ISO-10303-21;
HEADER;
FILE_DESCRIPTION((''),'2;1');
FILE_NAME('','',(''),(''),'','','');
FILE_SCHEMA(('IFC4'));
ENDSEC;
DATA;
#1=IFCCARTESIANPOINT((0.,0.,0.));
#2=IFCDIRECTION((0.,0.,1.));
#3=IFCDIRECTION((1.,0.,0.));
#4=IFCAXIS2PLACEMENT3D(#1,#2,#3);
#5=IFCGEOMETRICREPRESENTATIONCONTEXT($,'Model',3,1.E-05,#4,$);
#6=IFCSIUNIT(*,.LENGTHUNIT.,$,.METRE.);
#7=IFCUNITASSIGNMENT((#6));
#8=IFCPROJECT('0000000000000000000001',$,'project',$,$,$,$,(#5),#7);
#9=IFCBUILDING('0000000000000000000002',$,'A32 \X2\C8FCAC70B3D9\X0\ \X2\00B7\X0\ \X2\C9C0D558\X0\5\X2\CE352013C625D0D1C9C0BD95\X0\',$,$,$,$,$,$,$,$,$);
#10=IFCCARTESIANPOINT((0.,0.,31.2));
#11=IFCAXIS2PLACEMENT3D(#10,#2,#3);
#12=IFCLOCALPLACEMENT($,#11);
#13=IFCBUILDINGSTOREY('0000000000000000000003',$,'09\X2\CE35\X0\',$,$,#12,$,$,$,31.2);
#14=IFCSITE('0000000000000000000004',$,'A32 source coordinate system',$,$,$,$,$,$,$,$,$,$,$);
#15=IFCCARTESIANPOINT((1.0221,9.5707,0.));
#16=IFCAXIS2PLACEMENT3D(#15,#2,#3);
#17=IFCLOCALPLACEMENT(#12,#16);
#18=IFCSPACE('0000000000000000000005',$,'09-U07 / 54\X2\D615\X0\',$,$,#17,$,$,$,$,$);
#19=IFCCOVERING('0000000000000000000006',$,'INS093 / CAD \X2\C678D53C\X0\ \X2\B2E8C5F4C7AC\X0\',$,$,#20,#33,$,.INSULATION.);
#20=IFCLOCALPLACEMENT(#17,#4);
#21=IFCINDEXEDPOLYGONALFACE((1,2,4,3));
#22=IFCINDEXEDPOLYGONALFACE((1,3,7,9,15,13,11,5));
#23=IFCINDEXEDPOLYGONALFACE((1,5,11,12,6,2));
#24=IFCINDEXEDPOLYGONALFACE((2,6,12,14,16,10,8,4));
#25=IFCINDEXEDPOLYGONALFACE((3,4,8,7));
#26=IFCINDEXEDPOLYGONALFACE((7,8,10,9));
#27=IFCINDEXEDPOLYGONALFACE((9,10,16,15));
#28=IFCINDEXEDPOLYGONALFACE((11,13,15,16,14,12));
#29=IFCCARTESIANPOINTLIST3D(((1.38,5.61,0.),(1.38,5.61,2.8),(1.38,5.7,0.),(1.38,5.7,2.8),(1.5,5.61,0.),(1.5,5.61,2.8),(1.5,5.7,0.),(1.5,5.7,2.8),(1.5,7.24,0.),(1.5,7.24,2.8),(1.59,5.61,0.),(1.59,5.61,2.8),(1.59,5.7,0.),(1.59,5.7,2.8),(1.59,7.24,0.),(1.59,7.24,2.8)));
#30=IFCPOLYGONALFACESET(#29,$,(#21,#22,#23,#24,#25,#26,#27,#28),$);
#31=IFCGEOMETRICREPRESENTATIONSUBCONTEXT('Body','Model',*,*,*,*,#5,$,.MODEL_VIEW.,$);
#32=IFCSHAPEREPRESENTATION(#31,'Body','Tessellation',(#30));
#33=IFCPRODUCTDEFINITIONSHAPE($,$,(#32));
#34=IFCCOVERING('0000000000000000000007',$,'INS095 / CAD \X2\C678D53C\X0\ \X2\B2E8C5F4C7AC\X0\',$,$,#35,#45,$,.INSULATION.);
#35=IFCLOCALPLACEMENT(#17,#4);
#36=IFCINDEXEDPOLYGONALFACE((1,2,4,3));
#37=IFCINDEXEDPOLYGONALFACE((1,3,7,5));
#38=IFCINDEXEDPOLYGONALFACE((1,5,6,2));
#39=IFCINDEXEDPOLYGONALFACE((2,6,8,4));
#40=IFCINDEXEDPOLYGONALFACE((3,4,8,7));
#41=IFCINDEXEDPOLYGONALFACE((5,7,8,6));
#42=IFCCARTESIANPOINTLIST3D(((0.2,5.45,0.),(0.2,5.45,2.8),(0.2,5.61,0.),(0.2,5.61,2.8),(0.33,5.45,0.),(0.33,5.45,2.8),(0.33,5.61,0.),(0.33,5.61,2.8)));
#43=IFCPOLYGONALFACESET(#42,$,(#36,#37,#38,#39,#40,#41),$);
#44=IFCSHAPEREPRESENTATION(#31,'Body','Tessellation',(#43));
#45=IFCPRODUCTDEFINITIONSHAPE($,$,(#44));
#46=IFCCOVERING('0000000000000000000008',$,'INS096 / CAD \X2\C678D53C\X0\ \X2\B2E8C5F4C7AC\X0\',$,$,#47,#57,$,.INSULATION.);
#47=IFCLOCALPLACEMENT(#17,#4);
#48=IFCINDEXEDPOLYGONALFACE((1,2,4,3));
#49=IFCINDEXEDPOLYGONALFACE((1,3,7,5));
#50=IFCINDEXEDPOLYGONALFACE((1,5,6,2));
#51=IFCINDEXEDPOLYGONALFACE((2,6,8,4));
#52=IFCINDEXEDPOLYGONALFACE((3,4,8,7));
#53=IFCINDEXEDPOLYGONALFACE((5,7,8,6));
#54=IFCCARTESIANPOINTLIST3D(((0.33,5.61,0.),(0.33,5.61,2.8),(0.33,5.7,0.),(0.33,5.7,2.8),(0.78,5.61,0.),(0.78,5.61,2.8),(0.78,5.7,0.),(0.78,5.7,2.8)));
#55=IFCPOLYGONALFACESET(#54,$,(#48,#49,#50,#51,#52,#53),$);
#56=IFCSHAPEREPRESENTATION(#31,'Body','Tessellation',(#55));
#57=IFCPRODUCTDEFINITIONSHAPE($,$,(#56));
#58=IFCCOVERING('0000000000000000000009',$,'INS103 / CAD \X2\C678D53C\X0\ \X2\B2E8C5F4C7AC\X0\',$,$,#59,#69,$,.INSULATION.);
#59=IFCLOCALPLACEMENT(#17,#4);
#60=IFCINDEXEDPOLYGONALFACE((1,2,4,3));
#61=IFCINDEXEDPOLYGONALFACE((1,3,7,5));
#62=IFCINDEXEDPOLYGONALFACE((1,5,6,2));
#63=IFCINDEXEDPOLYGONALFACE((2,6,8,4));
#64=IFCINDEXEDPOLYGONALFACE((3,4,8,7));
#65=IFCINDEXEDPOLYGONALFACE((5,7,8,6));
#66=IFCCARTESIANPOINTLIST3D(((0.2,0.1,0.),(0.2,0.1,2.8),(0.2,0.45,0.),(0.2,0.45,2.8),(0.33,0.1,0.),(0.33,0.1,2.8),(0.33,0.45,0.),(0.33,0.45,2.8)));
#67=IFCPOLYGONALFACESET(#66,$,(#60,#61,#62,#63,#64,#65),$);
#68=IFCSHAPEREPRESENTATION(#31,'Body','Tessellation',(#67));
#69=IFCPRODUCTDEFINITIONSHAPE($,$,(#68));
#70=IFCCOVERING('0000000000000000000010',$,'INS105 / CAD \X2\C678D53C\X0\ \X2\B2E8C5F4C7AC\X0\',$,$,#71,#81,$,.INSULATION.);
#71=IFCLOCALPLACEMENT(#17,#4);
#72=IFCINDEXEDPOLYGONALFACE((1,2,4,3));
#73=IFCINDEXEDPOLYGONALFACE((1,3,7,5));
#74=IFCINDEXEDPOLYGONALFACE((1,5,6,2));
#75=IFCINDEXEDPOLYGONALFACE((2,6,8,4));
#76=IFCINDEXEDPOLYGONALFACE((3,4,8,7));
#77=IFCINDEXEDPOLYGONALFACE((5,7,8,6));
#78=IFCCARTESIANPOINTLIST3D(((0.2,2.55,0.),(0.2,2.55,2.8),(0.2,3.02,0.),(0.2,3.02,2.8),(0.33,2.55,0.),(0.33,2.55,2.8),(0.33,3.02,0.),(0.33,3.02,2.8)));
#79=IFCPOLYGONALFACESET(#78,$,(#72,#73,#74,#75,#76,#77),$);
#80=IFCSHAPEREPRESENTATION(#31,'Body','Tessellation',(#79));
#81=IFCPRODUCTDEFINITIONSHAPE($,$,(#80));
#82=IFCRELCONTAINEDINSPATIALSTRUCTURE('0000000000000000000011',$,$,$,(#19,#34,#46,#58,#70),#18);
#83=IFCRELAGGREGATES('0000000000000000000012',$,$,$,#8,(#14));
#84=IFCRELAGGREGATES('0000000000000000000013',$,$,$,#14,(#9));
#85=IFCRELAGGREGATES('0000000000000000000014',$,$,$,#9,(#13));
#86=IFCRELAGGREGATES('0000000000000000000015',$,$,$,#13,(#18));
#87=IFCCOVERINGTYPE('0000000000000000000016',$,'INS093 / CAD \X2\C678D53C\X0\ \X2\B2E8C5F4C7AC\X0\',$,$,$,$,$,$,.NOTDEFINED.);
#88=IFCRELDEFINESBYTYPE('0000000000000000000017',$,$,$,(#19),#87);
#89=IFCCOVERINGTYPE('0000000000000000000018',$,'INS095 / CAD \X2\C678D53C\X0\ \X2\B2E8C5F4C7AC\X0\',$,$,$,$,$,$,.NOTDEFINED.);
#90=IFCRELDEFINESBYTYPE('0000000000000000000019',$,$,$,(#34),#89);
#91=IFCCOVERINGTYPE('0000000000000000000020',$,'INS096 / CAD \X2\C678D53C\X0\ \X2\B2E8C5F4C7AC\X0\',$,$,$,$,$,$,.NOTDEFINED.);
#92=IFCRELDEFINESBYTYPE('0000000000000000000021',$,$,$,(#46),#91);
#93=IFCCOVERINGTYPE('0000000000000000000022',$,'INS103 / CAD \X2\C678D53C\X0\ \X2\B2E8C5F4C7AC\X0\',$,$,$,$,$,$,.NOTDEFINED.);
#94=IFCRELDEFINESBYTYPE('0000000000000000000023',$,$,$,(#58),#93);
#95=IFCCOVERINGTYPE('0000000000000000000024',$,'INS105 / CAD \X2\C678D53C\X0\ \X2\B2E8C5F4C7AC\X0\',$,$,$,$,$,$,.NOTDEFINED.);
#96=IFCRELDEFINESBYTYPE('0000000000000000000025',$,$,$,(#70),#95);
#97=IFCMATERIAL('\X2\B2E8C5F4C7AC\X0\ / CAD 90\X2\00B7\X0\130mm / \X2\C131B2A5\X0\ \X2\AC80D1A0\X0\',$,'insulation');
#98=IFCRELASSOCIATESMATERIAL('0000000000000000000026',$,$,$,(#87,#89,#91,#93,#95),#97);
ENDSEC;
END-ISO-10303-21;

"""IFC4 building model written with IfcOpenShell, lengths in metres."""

from ifc_helpers import new_model, si_unit, frame, origin, origin_with_axes, place, context, subcontext, project, spatial, polyline, outline, extrude, source, transform, mapped, material, type_object, type_shapes, element, save


model = new_model("IFC4")

# Units and contexts
model_context = context("Model", 3, precision=1e-05, world=origin_with_axes())
body_context = subcontext(model_context, "Body", "Model", "MODEL_VIEW")
ifc_project = project(units=[si_unit("LENGTHUNIT", "METRE")], contexts=[model_context])

# Site, building, storey, space
storey_placement = place(None, frame((0.0, 0.0, 31.2), z_axis=(0.0, 0.0, 1.0), x_axis=(1.0, 0.0, 0.0)))
space_placement = place(storey_placement, frame((1.0221, 9.5707, 0.0), z_axis=(0.0, 0.0, 1.0), x_axis=(1.0, 0.0, 0.0)))
site = spatial("IfcSite", under=ifc_project, Name="A32 source coordinate system")
building = spatial("IfcBuilding", under=site, Name="A32 주거동 · 지하5층–옥탑지붕")
storey = spatial("IfcBuildingStorey", under=building, at=storey_placement, Name="09층", Elevation=31.2)
space = spatial("IfcSpace", under=storey, at=space_placement, Name="09-U07 / 54형")

# Coverings
ifc_material = material(Name="단열재 / CAD 90·130mm / 성능 검토", Category="insulation")
covering_type_1 = type_object("IfcCoveringType", Name="INS093 / CAD 외피 단열재", PredefinedType="NOTDEFINED", material=ifc_material)
shared_shape_1 = source(origin(), body_context, "Body", "SweptSolid", [
    extrude(outline(polyline([(1.5, 5.7), (1.5, 7.24), (1.59, 7.24), (1.59, 5.7), (1.59, 5.61), (1.5, 5.61), (1.38, 5.61), (1.38, 5.7), (1.5, 5.7)])), origin(), (0.0, 0.0, 1.0), 2.8),
])
type_shapes(covering_type_1, [shared_shape_1])
covering_1_placement = place(space_placement, origin_with_axes())
element("IfcCovering", 1, at=covering_1_placement, inside=space, type_object=covering_type_1, Name="INS093 / CAD 외피 단열재", PredefinedType="INSULATION", context=body_context, shape_type="MappedRepresentation", body=[
    mapped(shared_shape_1, transform((0.0, 0.0, 0.0), scale=1.0)),
])
covering_type_2 = type_object("IfcCoveringType", Name="INS095 / CAD 외피 단열재", PredefinedType="NOTDEFINED", material=ifc_material)
shared_shape_2 = source(origin(), body_context, "Body", "SweptSolid", [
    extrude(outline(polyline([(0.2, 5.61), (0.33, 5.61), (0.33, 5.45), (0.2, 5.45), (0.2, 5.61)])), origin(), (0.0, 0.0, 1.0), 2.8),
])
type_shapes(covering_type_2, [shared_shape_2])
covering_2_placement = place(space_placement, origin_with_axes())
element("IfcCovering", 2, at=covering_2_placement, inside=space, type_object=covering_type_2, Name="INS095 / CAD 외피 단열재", PredefinedType="INSULATION", context=body_context, shape_type="MappedRepresentation", body=[
    mapped(shared_shape_2, transform((0.0, 0.0, 0.0), scale=1.0)),
])
covering_type_3 = type_object("IfcCoveringType", Name="INS096 / CAD 외피 단열재", PredefinedType="NOTDEFINED", material=ifc_material)
shared_shape_3 = source(origin(), body_context, "Body", "SweptSolid", [
    extrude(outline(polyline([(0.78, 5.7), (0.78, 5.61), (0.33, 5.61), (0.33, 5.7), (0.78, 5.7)])), origin(), (0.0, 0.0, 1.0), 2.8),
])
type_shapes(covering_type_3, [shared_shape_3])
covering_3_placement = place(space_placement, origin_with_axes())
element("IfcCovering", 3, at=covering_3_placement, inside=space, type_object=covering_type_3, Name="INS096 / CAD 외피 단열재", PredefinedType="INSULATION", context=body_context, shape_type="MappedRepresentation", body=[
    mapped(shared_shape_3, transform((0.0, 0.0, 0.0), scale=1.0)),
])
covering_type_4 = type_object("IfcCoveringType", Name="INS103 / CAD 외피 단열재", PredefinedType="NOTDEFINED", material=ifc_material)
shared_shape_4 = source(origin(), body_context, "Body", "SweptSolid", [
    extrude(outline(polyline([(0.2, 0.45), (0.33, 0.45), (0.33, 0.1), (0.2, 0.1), (0.2, 0.45)])), origin(), (0.0, 0.0, 1.0), 2.8),
])
type_shapes(covering_type_4, [shared_shape_4])
covering_4_placement = place(space_placement, origin_with_axes())
element("IfcCovering", 4, at=covering_4_placement, inside=space, type_object=covering_type_4, Name="INS103 / CAD 외피 단열재", PredefinedType="INSULATION", context=body_context, shape_type="MappedRepresentation", body=[
    mapped(shared_shape_4, transform((0.0, 0.0, 0.0), scale=1.0)),
])
covering_type_5 = type_object("IfcCoveringType", Name="INS105 / CAD 외피 단열재", PredefinedType="NOTDEFINED", material=ifc_material)
shared_shape_5 = source(origin(), body_context, "Body", "SweptSolid", [
    extrude(outline(polyline([(0.2, 3.02), (0.33, 3.02), (0.33, 2.55), (0.2, 2.55), (0.2, 3.02)])), origin(), (0.0, 0.0, 1.0), 2.8),
])
type_shapes(covering_type_5, [shared_shape_5])
covering_5_placement = place(space_placement, origin_with_axes())
element("IfcCovering", 5, at=covering_5_placement, inside=space, type_object=covering_type_5, Name="INS105 / CAD 외피 단열재", PredefinedType="INSULATION", context=body_context, shape_type="MappedRepresentation", body=[
    mapped(shared_shape_5, transform((0.0, 0.0, 0.0), scale=1.0)),
])

save(model, "model.ifc")
